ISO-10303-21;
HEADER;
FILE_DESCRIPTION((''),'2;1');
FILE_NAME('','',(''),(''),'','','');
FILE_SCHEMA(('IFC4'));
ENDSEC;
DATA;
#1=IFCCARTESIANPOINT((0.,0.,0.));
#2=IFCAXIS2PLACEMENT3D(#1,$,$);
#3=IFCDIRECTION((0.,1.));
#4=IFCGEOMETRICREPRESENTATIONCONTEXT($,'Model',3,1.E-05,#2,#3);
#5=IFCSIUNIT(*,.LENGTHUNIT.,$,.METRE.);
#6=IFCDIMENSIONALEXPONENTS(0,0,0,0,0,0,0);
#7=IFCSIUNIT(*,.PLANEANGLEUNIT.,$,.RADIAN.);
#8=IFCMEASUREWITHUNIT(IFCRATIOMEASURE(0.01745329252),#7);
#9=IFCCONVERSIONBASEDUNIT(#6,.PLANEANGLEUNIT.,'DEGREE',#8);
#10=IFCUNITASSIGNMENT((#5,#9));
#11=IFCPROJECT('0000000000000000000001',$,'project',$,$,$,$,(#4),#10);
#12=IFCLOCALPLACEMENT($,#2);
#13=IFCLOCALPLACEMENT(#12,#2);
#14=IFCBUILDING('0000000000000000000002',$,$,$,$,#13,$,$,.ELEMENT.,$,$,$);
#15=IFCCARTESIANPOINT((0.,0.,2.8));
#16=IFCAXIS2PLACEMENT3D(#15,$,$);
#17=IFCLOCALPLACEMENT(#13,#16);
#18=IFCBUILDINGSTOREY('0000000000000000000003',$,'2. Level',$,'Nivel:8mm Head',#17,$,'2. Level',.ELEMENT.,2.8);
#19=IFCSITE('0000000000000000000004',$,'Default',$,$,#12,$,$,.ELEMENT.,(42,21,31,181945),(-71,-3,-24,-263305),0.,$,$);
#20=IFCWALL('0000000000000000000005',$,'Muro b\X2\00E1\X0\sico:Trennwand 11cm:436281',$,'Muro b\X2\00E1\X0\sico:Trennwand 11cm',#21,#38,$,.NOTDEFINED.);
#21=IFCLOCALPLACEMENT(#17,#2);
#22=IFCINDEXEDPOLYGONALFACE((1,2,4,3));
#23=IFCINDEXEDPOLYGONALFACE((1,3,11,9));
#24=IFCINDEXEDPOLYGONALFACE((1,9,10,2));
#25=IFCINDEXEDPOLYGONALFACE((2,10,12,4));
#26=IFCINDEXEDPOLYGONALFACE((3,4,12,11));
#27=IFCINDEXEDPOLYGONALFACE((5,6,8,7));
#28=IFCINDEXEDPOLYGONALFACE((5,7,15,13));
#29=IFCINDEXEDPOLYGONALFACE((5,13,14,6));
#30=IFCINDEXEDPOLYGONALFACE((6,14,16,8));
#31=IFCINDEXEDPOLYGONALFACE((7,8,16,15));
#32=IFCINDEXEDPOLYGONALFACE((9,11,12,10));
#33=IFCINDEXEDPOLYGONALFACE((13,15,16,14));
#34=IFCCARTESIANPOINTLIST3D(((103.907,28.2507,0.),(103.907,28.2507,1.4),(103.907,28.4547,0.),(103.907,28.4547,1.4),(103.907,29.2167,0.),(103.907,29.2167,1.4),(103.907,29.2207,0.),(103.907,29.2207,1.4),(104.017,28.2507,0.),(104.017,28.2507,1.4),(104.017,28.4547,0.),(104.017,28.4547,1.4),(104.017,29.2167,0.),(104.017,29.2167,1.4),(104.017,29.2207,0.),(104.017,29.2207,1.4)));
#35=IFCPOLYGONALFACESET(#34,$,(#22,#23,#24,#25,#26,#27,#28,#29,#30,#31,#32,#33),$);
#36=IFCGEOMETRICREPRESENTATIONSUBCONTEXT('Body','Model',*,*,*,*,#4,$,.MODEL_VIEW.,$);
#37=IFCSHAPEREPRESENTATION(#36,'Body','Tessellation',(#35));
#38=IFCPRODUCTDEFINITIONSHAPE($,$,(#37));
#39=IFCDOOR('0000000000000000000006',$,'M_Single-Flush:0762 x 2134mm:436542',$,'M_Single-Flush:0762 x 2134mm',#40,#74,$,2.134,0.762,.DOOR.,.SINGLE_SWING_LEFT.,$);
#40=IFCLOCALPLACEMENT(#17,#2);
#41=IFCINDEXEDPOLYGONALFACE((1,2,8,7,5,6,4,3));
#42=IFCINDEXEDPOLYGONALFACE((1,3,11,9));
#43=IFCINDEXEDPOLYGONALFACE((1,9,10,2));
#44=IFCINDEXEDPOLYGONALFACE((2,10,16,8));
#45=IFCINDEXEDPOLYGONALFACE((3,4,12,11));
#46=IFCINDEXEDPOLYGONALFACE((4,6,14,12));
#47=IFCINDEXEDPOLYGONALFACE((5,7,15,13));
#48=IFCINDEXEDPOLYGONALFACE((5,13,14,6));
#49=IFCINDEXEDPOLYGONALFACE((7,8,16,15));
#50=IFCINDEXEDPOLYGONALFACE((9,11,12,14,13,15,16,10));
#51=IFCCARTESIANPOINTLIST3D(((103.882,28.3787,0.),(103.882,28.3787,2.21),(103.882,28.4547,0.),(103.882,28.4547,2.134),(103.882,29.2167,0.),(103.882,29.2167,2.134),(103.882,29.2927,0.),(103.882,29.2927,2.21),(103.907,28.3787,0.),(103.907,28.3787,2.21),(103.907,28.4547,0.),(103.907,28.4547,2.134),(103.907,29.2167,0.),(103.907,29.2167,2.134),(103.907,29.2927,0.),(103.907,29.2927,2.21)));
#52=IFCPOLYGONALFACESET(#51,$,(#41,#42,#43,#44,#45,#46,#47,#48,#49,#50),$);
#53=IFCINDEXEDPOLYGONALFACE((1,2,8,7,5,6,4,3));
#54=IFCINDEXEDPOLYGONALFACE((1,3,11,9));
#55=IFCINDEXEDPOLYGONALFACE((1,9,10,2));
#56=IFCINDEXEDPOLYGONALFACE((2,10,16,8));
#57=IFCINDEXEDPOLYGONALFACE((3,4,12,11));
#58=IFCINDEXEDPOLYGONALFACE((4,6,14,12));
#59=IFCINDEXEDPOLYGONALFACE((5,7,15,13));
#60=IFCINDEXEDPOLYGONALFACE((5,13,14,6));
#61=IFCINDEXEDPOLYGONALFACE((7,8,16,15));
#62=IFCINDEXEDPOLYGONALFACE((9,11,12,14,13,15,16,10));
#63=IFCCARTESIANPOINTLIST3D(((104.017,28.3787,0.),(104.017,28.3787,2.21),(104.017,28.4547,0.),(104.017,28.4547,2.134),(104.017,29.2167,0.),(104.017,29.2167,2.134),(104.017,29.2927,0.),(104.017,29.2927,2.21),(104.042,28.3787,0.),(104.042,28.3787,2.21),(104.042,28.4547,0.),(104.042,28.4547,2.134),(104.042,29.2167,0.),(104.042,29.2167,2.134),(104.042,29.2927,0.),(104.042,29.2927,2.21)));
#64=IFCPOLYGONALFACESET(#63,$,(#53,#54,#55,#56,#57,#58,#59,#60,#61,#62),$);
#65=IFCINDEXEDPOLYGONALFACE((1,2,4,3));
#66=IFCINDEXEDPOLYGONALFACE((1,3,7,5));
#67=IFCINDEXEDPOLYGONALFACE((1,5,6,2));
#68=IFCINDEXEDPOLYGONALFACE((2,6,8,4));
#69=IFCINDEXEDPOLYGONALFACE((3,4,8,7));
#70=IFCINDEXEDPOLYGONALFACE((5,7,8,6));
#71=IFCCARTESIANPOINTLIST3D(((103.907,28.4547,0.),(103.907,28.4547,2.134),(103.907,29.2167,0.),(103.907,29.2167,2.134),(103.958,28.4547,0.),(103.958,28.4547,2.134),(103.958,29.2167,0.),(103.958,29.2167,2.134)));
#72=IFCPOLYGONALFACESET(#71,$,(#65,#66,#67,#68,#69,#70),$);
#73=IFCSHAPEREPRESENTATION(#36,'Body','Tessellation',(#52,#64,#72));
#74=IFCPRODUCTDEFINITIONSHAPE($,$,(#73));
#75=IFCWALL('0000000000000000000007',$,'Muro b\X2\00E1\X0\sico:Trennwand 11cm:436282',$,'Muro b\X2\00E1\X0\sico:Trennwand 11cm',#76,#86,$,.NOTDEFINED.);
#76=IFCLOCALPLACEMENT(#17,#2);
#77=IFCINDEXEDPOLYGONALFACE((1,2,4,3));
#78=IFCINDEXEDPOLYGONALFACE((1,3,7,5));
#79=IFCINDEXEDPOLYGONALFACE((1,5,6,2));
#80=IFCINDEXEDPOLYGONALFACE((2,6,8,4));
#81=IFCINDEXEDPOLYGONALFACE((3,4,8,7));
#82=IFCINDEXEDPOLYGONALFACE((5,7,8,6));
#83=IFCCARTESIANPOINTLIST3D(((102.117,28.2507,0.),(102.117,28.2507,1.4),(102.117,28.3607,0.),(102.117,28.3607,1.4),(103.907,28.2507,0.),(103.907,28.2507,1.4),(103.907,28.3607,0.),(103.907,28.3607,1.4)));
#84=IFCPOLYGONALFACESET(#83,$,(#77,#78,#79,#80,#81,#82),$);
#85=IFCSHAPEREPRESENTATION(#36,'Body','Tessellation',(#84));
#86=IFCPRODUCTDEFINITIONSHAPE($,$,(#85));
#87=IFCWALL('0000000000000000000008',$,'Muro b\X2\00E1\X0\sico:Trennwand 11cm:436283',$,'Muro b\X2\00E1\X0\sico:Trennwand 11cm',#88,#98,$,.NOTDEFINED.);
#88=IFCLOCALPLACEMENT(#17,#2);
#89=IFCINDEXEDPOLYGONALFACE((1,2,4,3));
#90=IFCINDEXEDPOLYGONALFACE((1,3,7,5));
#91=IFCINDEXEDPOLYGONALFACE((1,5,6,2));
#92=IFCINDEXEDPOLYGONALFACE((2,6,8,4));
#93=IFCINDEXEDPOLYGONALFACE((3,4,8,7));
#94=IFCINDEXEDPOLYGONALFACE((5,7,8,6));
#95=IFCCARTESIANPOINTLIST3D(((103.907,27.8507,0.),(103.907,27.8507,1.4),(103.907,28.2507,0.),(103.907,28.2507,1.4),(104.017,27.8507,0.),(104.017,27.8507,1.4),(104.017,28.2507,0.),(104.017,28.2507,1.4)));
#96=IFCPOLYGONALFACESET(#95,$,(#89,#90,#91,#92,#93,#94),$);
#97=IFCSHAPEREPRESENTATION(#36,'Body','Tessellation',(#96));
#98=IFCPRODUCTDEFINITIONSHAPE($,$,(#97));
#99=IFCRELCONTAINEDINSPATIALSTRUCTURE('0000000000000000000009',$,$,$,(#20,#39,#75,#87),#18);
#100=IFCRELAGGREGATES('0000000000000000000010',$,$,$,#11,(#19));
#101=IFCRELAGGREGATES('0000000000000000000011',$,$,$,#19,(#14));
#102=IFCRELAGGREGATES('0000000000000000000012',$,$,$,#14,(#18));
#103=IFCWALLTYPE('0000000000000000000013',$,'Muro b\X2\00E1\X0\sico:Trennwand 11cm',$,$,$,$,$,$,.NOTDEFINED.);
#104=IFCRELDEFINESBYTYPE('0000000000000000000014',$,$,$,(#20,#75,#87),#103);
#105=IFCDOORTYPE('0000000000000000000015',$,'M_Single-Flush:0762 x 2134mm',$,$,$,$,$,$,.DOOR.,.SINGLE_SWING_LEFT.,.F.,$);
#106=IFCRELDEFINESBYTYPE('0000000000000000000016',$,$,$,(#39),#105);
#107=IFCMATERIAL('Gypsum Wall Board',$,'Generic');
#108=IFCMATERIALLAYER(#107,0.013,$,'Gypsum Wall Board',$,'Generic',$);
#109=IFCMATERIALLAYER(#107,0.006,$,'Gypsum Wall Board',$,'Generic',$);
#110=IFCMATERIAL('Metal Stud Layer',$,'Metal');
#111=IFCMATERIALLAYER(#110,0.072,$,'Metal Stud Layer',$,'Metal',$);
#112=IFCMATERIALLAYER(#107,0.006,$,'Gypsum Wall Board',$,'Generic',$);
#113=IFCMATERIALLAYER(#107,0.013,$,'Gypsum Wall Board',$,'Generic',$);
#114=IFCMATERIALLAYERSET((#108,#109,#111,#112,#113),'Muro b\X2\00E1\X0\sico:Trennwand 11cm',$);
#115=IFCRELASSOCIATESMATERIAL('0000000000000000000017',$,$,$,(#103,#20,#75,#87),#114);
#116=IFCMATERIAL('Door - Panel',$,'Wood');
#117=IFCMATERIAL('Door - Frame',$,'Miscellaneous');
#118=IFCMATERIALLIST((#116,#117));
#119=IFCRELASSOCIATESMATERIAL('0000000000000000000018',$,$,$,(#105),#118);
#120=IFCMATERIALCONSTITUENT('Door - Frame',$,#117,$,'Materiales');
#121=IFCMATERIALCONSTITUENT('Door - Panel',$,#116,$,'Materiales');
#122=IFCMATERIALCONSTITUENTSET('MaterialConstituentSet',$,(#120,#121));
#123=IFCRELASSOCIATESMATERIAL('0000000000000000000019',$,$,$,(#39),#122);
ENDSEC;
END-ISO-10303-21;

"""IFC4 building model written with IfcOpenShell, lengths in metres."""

from ifc_helpers import new_model, entity, si_unit, converted_unit, direction, frame, frame_2d, origin, origin_2d_with_axis, place, context, subcontext, project, spatial, polyline, rectangle, outline, extrude, clip, halfspace, source, transform, mapped, material, material_list, layer, layer_set, layer_usage, constituent, constituent_set, type_object, type_shapes, element, fill, save


model = new_model("IFC4")

# Units and contexts
model_context = context("Model", 3, precision=1e-05, world=origin(), true_north=direction((0.0, 1.0)))
body_context = subcontext(model_context, "Body", "Model", "MODEL_VIEW")
ifc_project = project(units=[si_unit("LENGTHUNIT", "METRE"), converted_unit("PLANEANGLEUNIT", "DEGREE", entity("IfcRatioMeasure", 0.01745329252), si_unit("PLANEANGLEUNIT", "RADIAN"), dimensions=[0, 0, 0, 0, 0, 0, 0])], contexts=[model_context])

# Site, building, storey
site_placement = place(None, origin())
site = spatial("IfcSite", under=ifc_project, at=site_placement, Name="Default", CompositionType="ELEMENT", RefLatitude=(42, 21, 31, 181945), RefLongitude=(-71, -3, -24, -263305), RefElevation=0.0)
building_placement = place(site_placement, origin())
building = spatial("IfcBuilding", under=site, at=building_placement, CompositionType="ELEMENT")
storey_placement = place(building_placement, frame((0.0, 0.0, 2.8)))
storey = spatial("IfcBuildingStorey", under=building, at=storey_placement, Name="2. Level", ObjectType="Nivel:8mm Head", LongName="2. Level", CompositionType="ELEMENT", Elevation=2.8)

# Shared definitions
ifc_material_1 = material(Name="Gypsum Wall Board", Category="Generic")
ifc_layer_1 = layer(ifc_material_1, 0.013, Name="Gypsum Wall Board", Category="Generic")
ifc_layer_2 = layer(ifc_material_1, 0.006, Name="Gypsum Wall Board", Category="Generic")
ifc_material_2 = material(Name="Metal Stud Layer", Category="Metal")
ifc_layer_3 = layer(ifc_material_2, 0.072, Name="Metal Stud Layer", Category="Metal")
ifc_layer_4 = layer(ifc_material_1, 0.006, Name="Gypsum Wall Board", Category="Generic")
ifc_layer_5 = layer(ifc_material_1, 0.013, Name="Gypsum Wall Board", Category="Generic")
ifc_layer_set_1 = layer_set([ifc_layer_1, ifc_layer_2, ifc_layer_3, ifc_layer_4, ifc_layer_5], Name="Muro básico:Trennwand 11cm")
wall_type_1 = type_object("IfcWallType", Name="Muro básico:Trennwand 11cm", PredefinedType="NOTDEFINED", material=ifc_layer_set_1)

# Shared definitions
ifc_material_3 = material(Name="Door - Frame", Category="Miscellaneous")
ifc_material_4 = material(Name="Door - Panel", Category="Wood")
ifc_material_list_1 = material_list([ifc_material_4, ifc_material_3])
door_type_1 = type_object("IfcDoorType", Name="M_Single-Flush:0762 x 2134mm", OperationType="SINGLE_SWING_LEFT", ParameterTakesPrecedence=False, PredefinedType="DOOR", material=ifc_material_list_1)
shared_shape_1 = source(origin(), body_context, "Body", "SweptSolid", [
    extrude(outline(polyline([(-0.457, -1.124), (0.457, -1.124), (0.457, 1.086), (0.381, 1.086), (0.381, -1.048), (-0.381, -1.048), (-0.381, 1.086), (-0.457, 1.086), (-0.457, -1.124)])), frame((0.381, 0.135, 1.086), z_axis=(0.0, -1.0, 0.0), x_axis=(-1.0, 0.0, 0.0)), (0.0, 0.0, 1.0), 0.025),
    extrude(outline(polyline([(-1.124, -0.457), (1.086, -0.457), (1.086, -0.381), (-1.048, -0.381), (-1.048, 0.381), (1.086, 0.381), (1.086, 0.457), (-1.124, 0.457), (-1.124, -0.457)])), frame((0.381, 0.0, 1.086), z_axis=(0.0, -1.0, 0.0), x_axis=(0.0, 0.0, -1.0)), (0.0, 0.0, 1.0), 0.025),
    extrude(rectangle(XDim=0.762, YDim=0.051, at=origin_2d_with_axis()), frame((0.381, 0.0845, 0.0)), (0.0, 0.0, 1.0), 2.134),
])
type_shapes(door_type_1, [shared_shape_1])

# Wall, opening, door
ifc_layer_usage_1 = layer_usage(ifc_layer_set_1, "AXIS2", "NEGATIVE", 0.055)
wall_1_placement = place(storey_placement, frame((103.962, 28.2507, 0.0), z_axis=(0.0, 0.0, 1.0), x_axis=(0.0, 1.0, 0.0)))
wall_1 = element("IfcWall", 1, at=wall_1_placement, inside=storey, type_object=wall_type_1, material=ifc_layer_usage_1, Name="Muro básico:Trennwand 11cm:436281", ObjectType="Muro básico:Trennwand 11cm", PredefinedType="NOTDEFINED", context=body_context, shape_type="Clipping", body=[
    clip(extrude(rectangle(XDim=0.97, YDim=0.11, at=frame_2d((0.485, 0.0), x_axis=(-1.0, 0.0))), origin(), (0.0, 0.0, 1.0), 1.4), halfspace(origin(), True)),
])
opening_1_placement = place(wall_1_placement, frame((0.204, -0.055, 0.0)))
opening_1 = element("IfcOpeningElement", 2, at=opening_1_placement, cuts=wall_1, ObjectType="Opening", PredefinedType="OPENING", context=body_context, shape_type="SweptSolid", body=[
    extrude(rectangle(XDim=0.762, YDim=2.134, at=frame_2d((1.067, 0.381), x_axis=(0.0, -1.0))), frame((0.0, 0.0, 0.0), z_axis=(0.0, 1.0, 0.0), x_axis=(0.0, 0.0, 1.0)), (0.0, 0.0, 1.0), 0.11),
])
ifc_constituent_1 = constituent(ifc_material_3, Name="Door - Frame", Category="Materiales")
ifc_constituent_2 = constituent(ifc_material_4, Name="Door - Panel", Category="Materiales")
ifc_constituent_set_1 = constituent_set(constituents=[ifc_constituent_1, ifc_constituent_2], Name="MaterialConstituentSet")
door_1_placement = place(opening_1_placement, origin())
door_1 = element("IfcDoor", 3, at=door_1_placement, inside=storey, type_object=door_type_1, material=ifc_constituent_set_1, Name="M_Single-Flush:0762 x 2134mm:436542", ObjectType="M_Single-Flush:0762 x 2134mm", OperationType="SINGLE_SWING_LEFT", OverallHeight=2.134, OverallWidth=0.762, PredefinedType="DOOR", context=body_context, shape_type="MappedRepresentation", body=[
    mapped(shared_shape_1, transform((0.0, 0.0, 0.0), scale=1.0)),
])
fill(opening_1, door_1)

# Walls
ifc_layer_usage_2 = layer_usage(ifc_layer_set_1, "AXIS2", "NEGATIVE", 0.055)
wall_2_placement = place(storey_placement, frame((102.117, 28.3057, 0.0)))
element("IfcWall", 4, at=wall_2_placement, inside=storey, type_object=wall_type_1, material=ifc_layer_usage_2, Name="Muro básico:Trennwand 11cm:436282", ObjectType="Muro básico:Trennwand 11cm", PredefinedType="NOTDEFINED", context=body_context, shape_type="Clipping", body=[
    clip(extrude(rectangle(XDim=1.79, YDim=0.11, at=frame_2d((0.895, 0.0), x_axis=(-1.0, 0.0))), origin(), (0.0, 0.0, 1.0), 1.4), halfspace(origin(), True)),
])
ifc_layer_usage_3 = layer_usage(ifc_layer_set_1, "AXIS2", "NEGATIVE", 0.055)
wall_3_placement = place(storey_placement, frame((103.962, 28.2507, 0.0), z_axis=(0.0, 0.0, 1.0), x_axis=(0.0, -1.0, 0.0)))
element("IfcWall", 5, at=wall_3_placement, inside=storey, type_object=wall_type_1, material=ifc_layer_usage_3, Name="Muro básico:Trennwand 11cm:436283", ObjectType="Muro básico:Trennwand 11cm", PredefinedType="NOTDEFINED", context=body_context, shape_type="Clipping", body=[
    clip(extrude(rectangle(XDim=0.4, YDim=0.11, at=frame_2d((0.2, 0.0), x_axis=(-1.0, 0.0))), origin(), (0.0, 0.0, 1.0), 1.4), halfspace(origin(), True)),
])

save(model, "model.ifc")
